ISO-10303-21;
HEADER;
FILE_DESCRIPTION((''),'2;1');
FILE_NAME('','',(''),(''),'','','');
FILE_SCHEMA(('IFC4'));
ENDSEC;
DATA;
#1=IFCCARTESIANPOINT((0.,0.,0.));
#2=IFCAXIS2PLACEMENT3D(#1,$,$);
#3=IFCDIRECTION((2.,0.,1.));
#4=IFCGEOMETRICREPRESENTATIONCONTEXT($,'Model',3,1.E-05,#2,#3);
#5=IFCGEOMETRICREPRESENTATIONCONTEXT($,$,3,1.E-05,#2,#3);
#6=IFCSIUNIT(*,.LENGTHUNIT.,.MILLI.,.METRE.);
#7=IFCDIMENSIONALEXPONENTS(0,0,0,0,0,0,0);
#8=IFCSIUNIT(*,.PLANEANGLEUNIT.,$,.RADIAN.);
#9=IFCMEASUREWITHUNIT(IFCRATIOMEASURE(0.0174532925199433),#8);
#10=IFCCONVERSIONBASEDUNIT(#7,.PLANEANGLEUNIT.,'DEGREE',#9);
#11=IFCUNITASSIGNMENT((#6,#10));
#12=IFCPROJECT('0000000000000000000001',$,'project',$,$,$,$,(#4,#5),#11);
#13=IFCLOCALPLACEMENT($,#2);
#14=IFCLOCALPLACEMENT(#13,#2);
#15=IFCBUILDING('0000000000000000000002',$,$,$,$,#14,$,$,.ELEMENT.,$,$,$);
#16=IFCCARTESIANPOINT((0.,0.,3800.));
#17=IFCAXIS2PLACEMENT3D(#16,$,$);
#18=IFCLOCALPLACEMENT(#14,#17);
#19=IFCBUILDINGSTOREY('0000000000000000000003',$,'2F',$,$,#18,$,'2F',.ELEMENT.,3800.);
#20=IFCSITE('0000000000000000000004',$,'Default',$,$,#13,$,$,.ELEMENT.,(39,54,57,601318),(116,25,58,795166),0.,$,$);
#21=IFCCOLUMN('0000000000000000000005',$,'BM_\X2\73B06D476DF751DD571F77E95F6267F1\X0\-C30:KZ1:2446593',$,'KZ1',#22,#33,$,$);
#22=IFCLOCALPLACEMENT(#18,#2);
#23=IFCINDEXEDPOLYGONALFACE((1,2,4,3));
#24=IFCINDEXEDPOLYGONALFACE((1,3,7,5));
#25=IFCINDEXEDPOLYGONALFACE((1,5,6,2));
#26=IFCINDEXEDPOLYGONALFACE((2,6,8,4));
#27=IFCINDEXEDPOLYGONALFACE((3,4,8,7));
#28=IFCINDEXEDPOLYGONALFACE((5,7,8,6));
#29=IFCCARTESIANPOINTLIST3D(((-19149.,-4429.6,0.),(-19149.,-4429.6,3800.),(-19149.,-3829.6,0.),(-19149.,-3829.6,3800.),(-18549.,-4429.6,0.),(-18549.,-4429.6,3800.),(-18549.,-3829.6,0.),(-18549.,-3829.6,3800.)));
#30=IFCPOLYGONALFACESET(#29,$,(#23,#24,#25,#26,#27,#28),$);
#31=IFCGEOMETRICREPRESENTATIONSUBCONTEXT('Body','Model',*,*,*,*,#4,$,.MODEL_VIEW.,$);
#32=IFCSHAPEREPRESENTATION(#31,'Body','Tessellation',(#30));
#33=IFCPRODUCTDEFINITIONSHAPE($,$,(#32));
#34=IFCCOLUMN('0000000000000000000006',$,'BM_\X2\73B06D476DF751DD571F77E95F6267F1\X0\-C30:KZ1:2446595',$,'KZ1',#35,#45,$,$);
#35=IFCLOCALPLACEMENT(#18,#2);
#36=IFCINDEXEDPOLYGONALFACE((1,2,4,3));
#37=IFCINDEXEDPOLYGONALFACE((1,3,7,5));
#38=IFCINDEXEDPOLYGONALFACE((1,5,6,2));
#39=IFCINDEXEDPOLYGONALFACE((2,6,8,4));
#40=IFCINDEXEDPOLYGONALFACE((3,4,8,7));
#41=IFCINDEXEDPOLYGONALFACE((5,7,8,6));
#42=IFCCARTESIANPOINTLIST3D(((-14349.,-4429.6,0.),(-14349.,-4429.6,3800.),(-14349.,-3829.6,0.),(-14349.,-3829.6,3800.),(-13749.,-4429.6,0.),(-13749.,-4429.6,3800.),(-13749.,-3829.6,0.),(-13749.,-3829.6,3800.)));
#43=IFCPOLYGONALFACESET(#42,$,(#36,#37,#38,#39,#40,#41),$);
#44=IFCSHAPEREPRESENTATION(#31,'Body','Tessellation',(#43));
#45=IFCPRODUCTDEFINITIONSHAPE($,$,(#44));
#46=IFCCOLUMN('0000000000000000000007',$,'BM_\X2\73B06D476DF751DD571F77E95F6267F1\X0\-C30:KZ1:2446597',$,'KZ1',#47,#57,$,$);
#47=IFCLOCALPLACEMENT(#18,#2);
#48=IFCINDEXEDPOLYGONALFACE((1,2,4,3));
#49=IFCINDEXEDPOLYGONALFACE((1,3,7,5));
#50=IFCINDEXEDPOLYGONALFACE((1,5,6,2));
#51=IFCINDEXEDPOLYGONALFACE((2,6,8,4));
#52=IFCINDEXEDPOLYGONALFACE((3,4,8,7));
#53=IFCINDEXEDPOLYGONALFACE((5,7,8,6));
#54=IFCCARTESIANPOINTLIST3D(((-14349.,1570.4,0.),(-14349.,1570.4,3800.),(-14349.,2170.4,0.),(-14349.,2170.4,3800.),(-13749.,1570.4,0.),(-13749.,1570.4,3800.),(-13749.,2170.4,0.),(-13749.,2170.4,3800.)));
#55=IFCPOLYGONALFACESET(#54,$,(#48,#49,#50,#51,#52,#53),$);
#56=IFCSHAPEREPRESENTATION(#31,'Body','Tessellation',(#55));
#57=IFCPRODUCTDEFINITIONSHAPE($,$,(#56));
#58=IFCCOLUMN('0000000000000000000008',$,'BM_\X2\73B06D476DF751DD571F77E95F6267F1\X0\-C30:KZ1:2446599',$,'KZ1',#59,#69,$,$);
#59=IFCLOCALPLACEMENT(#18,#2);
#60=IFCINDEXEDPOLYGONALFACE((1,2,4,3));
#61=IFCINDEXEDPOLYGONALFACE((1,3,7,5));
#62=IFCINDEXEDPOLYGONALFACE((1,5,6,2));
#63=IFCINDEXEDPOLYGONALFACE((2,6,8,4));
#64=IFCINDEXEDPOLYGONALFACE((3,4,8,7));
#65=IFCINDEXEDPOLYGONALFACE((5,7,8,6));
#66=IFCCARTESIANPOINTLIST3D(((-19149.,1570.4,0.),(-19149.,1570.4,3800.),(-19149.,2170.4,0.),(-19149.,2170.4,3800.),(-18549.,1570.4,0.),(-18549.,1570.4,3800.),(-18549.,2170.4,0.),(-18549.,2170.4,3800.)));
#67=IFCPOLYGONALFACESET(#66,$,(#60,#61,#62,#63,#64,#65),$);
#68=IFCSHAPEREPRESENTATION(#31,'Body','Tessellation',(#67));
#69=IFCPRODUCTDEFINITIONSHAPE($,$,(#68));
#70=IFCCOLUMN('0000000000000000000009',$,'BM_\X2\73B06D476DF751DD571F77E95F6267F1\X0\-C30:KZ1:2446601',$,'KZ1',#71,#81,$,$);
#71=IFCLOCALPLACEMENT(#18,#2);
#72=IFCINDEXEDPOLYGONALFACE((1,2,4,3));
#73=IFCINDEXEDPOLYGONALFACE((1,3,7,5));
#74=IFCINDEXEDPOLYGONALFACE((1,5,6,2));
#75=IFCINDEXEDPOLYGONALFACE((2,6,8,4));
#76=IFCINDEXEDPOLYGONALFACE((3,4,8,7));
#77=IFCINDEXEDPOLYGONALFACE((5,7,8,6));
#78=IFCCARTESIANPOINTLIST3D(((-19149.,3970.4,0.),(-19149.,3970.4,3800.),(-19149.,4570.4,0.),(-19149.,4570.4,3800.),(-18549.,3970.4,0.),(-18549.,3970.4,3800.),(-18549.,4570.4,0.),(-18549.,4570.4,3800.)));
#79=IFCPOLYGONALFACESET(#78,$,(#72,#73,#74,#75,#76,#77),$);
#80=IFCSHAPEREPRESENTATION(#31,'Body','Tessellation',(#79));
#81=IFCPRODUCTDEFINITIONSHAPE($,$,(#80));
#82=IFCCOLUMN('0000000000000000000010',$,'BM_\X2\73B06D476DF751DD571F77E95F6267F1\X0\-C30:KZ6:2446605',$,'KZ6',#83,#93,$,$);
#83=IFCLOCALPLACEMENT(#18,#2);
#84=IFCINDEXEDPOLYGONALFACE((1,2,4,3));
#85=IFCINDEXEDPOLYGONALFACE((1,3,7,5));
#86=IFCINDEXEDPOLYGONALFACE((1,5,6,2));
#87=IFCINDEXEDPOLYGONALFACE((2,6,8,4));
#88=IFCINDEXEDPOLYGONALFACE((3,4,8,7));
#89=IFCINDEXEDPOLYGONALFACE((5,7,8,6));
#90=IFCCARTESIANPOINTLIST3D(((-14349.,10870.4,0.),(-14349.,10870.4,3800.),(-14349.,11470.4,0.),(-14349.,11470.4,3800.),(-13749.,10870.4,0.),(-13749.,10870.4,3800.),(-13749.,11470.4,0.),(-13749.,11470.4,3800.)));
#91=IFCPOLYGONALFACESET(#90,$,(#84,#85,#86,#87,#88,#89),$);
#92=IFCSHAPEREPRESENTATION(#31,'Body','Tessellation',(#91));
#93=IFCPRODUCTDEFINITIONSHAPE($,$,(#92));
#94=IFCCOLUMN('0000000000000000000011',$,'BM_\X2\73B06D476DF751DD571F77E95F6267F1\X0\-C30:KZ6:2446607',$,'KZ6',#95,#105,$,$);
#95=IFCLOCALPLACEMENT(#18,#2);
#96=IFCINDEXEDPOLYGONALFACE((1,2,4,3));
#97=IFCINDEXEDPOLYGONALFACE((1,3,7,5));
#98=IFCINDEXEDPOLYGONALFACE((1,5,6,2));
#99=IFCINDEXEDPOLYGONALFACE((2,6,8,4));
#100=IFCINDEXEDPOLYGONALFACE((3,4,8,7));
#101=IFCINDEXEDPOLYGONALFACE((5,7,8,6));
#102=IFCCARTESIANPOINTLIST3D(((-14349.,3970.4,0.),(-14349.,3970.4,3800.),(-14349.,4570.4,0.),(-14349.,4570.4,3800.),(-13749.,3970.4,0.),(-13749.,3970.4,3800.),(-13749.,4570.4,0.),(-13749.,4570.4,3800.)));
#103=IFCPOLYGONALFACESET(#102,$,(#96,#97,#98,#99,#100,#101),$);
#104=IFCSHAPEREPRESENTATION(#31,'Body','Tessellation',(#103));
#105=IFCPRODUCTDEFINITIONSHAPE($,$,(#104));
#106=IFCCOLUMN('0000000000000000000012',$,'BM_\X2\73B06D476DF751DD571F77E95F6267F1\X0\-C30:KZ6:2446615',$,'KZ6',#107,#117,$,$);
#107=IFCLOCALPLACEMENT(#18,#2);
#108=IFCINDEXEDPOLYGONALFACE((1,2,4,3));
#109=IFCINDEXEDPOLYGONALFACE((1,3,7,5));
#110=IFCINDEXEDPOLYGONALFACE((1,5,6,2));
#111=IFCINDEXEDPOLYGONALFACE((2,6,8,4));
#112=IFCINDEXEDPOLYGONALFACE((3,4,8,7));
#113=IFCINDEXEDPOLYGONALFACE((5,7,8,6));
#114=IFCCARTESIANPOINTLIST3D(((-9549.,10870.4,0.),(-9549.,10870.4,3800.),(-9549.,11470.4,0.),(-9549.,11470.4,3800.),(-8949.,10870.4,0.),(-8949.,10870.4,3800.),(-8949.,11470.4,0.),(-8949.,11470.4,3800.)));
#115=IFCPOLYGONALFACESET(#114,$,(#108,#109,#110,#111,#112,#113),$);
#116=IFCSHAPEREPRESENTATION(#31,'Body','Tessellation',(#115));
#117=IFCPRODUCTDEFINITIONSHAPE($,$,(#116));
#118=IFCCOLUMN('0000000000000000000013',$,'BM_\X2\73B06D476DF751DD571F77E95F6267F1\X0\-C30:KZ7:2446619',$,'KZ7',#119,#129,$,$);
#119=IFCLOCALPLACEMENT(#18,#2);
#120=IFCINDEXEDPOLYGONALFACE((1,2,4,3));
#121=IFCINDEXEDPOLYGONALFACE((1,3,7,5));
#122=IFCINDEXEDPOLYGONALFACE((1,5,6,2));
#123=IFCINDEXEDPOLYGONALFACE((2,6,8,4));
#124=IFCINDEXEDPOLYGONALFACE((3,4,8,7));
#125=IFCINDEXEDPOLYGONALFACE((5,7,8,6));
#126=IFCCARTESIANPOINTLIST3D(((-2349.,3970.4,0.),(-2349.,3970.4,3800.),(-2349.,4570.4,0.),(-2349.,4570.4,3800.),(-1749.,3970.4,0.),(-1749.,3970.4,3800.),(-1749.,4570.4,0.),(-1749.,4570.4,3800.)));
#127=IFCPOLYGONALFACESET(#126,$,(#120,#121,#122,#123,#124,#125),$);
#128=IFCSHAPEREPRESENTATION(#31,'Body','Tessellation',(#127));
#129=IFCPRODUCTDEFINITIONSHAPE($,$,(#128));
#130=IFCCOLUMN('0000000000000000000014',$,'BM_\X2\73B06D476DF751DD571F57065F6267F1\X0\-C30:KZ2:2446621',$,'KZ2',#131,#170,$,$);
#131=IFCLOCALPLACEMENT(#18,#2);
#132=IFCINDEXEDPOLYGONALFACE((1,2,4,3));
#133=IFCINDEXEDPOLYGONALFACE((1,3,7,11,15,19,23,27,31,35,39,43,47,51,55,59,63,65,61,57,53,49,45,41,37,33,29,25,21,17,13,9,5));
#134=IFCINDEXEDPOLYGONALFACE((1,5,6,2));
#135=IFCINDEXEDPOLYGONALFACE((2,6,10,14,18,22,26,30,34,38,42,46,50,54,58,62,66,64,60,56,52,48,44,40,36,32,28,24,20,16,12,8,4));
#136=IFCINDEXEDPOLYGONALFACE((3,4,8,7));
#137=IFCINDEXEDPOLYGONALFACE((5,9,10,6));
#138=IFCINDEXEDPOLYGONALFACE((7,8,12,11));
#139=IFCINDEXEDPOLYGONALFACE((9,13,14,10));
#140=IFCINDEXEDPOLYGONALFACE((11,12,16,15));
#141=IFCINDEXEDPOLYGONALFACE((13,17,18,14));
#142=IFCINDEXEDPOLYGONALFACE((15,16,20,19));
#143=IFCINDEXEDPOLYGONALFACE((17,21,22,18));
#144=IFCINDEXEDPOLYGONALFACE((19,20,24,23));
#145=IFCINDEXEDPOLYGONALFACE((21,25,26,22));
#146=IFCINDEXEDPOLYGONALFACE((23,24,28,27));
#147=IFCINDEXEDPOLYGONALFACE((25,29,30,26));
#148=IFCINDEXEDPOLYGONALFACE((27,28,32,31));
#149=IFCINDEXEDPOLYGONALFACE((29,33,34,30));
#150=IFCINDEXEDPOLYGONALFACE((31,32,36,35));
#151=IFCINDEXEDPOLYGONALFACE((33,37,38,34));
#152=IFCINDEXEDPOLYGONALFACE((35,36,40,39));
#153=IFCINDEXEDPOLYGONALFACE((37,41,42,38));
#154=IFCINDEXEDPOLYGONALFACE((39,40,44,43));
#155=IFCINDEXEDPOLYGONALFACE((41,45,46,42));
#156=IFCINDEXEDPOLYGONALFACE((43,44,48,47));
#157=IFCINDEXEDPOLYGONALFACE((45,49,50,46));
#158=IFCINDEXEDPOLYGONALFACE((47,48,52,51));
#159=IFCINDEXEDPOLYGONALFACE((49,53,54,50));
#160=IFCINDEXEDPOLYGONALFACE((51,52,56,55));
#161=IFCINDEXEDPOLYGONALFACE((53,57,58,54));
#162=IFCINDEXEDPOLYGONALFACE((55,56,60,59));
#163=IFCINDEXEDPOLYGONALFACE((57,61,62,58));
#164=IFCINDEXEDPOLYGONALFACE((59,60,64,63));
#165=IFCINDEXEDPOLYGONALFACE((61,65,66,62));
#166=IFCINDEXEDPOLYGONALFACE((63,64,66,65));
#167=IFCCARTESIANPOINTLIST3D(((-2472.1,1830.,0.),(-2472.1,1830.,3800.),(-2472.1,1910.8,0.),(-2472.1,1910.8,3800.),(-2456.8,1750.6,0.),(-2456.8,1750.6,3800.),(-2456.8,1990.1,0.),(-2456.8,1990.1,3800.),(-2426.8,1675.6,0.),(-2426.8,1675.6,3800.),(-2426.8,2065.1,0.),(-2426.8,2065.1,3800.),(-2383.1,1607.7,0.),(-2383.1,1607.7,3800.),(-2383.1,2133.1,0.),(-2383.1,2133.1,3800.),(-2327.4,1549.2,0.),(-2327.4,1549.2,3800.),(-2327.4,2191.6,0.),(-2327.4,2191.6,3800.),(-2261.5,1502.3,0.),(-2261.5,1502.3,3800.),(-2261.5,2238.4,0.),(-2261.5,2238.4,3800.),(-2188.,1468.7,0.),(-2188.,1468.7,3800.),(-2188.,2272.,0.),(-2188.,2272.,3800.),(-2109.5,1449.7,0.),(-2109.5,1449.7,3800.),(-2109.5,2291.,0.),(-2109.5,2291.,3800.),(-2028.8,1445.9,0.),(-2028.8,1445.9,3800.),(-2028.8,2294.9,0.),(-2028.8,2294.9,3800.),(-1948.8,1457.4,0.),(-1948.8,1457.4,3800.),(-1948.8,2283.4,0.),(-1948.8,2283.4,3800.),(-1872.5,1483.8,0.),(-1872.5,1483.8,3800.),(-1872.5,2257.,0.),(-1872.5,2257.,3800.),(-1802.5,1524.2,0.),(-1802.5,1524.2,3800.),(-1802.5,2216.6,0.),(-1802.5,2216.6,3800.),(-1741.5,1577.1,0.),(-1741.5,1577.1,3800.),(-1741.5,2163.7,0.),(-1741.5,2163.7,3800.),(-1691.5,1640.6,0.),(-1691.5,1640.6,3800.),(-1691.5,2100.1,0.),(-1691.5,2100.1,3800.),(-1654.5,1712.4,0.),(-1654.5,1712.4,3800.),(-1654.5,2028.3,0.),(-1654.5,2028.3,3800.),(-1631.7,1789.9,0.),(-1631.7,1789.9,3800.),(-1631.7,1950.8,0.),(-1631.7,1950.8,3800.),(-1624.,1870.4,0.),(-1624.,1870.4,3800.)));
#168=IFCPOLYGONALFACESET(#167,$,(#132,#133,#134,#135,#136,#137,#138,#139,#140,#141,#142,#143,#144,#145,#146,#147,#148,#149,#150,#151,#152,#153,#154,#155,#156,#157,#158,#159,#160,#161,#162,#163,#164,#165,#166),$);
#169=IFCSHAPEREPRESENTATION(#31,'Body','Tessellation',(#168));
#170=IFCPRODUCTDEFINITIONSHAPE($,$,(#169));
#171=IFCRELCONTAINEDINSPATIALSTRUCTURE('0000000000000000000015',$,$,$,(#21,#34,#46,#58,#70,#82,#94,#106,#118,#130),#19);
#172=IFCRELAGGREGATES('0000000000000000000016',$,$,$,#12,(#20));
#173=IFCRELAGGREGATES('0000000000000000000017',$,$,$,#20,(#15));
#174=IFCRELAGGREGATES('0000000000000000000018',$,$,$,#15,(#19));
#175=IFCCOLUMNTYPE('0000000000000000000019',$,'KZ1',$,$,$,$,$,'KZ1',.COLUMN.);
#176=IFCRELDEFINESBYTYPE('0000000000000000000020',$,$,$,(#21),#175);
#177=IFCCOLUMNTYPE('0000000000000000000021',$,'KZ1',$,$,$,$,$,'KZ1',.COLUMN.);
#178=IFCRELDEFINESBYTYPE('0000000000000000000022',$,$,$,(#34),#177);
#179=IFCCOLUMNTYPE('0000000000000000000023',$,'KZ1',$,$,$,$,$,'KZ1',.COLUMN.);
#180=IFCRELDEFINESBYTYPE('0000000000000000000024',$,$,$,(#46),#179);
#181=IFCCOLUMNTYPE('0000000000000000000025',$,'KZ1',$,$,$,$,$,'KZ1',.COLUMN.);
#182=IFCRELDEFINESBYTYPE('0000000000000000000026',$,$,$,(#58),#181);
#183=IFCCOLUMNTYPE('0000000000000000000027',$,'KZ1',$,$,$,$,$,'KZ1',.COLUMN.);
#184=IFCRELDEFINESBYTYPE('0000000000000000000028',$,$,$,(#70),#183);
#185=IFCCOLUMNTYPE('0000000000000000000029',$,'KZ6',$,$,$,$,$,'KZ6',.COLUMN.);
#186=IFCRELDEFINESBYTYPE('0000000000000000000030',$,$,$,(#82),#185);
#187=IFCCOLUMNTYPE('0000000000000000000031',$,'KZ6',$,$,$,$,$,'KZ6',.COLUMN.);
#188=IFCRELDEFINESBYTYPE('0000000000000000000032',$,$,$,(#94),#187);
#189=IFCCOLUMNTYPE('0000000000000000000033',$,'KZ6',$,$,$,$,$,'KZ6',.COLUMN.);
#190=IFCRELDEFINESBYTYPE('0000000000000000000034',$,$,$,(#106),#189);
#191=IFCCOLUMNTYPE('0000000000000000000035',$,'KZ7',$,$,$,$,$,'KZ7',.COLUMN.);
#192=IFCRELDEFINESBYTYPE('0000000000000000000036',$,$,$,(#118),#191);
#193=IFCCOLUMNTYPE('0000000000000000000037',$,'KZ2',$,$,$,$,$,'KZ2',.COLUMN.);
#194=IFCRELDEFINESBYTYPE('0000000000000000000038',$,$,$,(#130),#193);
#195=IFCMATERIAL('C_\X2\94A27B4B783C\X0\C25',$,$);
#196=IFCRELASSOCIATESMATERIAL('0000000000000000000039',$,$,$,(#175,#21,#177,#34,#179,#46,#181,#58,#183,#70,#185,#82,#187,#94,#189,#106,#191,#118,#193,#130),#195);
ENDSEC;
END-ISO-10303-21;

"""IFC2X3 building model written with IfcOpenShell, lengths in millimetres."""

from ifc_helpers import new_model, entity, si_unit, converted_unit, direction, frame, frame_2d, origin, origin_2d_with_axis, place, context, subcontext, project, spatial, rectangle, circle, extrude, source, transform, mapped, material, type_object, type_shapes, element, save


model = new_model("IFC2X3")

# Units and contexts
model_context = context("Model", 3, precision=1e-05, world=origin(), true_north=direction((2.0, 0.0, 1.0)))
context_of_model = context(None, 3, precision=1e-05, world=origin(), true_north=direction((2.0, 0.0, 1.0)))
body_context = subcontext(model_context, "Body", "Model", "MODEL_VIEW")
ifc_project = project(units=[si_unit("LENGTHUNIT", "METRE", prefix="MILLI"), converted_unit("PLANEANGLEUNIT", "DEGREE", entity("IfcRatioMeasure", 0.0174532925199433), si_unit("PLANEANGLEUNIT", "RADIAN"), dimensions=[0, 0, 0, 0, 0, 0, 0])], contexts=[model_context, context_of_model])

# Site, building, storey
site_placement = place(None, origin())
site = spatial("IfcSite", under=ifc_project, at=site_placement, Name="Default", CompositionType="ELEMENT", RefLatitude=(39, 54, 57, 601318), RefLongitude=(116, 25, 58, 795166), RefElevation=0.0)
building_placement = place(site_placement, origin())
building = spatial("IfcBuilding", under=site, at=building_placement, CompositionType="ELEMENT")
storey_placement = place(building_placement, frame((0.0, 0.0, 3800.0)))
storey = spatial("IfcBuildingStorey", under=building, at=storey_placement, Name="2F", LongName="2F", CompositionType="ELEMENT", Elevation=3800.0)

# Columns
ifc_material_1 = material(Name="C_钢筋砼C25")
column_type_1 = type_object("IfcColumnType", Name="KZ1", ElementType="KZ1", PredefinedType="COLUMN", material=ifc_material_1)
shared_shape_1 = source(origin(), body_context, "Body", "SweptSolid", [
    extrude(rectangle(XDim=600.0, YDim=600.0, at=frame_2d((0.0, 0.0), x_axis=(1.0, 0.0))), frame((-18849.0, -4129.6, 3800.0), z_axis=(0.0, 0.0, 1.0), x_axis=(-1.0, 0.0, 0.0)), (0.0, 0.0, 1.0), 3800.0),
])
type_shapes(column_type_1, [shared_shape_1])
column_1_placement = place(storey_placement, frame((0.0, 0.0, -3800.0)))
element("IfcColumn", 1, at=column_1_placement, inside=storey, type_object=column_type_1, material=ifc_material_1, Name="BM_现浇混凝土矩形柱-C30:KZ1:2446593", ObjectType="KZ1", context=body_context, shape_type="MappedRepresentation", body=[
    mapped(shared_shape_1, transform((0.0, 0.0, 0.0), scale=1.0)),
])
column_type_2 = type_object("IfcColumnType", Name="KZ1", ElementType="KZ1", PredefinedType="COLUMN", material=ifc_material_1)
shared_shape_2 = source(origin(), body_context, "Body", "SweptSolid", [
    extrude(rectangle(XDim=600.0, YDim=600.0, at=frame_2d((0.0, 0.0), x_axis=(1.0, 0.0))), frame((-14049.0, -4129.6, 3800.0), z_axis=(0.0, 0.0, 1.0), x_axis=(-1.0, 0.0, 0.0)), (0.0, 0.0, 1.0), 3800.0),
])
type_shapes(column_type_2, [shared_shape_2])
column_2_placement = place(storey_placement, frame((0.0, 0.0, -3800.0)))
element("IfcColumn", 2, at=column_2_placement, inside=storey, type_object=column_type_2, material=ifc_material_1, Name="BM_现浇混凝土矩形柱-C30:KZ1:2446595", ObjectType="KZ1", context=body_context, shape_type="MappedRepresentation", body=[
    mapped(shared_shape_2, transform((0.0, 0.0, 0.0), scale=1.0)),
])
column_type_3 = type_object("IfcColumnType", Name="KZ1", ElementType="KZ1", PredefinedType="COLUMN", material=ifc_material_1)
shared_shape_3 = source(origin(), body_context, "Body", "SweptSolid", [
    extrude(rectangle(XDim=600.0, YDim=600.0, at=frame_2d((0.0, 0.0), x_axis=(1.0, 0.0))), frame((-14049.0, 1870.4, 3800.0), z_axis=(0.0, 0.0, 1.0), x_axis=(-1.0, 0.0, 0.0)), (0.0, 0.0, 1.0), 3800.0),
])
type_shapes(column_type_3, [shared_shape_3])
column_3_placement = place(storey_placement, frame((0.0, 0.0, -3800.0)))
element("IfcColumn", 3, at=column_3_placement, inside=storey, type_object=column_type_3, material=ifc_material_1, Name="BM_现浇混凝土矩形柱-C30:KZ1:2446597", ObjectType="KZ1", context=body_context, shape_type="MappedRepresentation", body=[
    mapped(shared_shape_3, transform((0.0, 0.0, 0.0), scale=1.0)),
])
column_type_4 = type_object("IfcColumnType", Name="KZ1", ElementType="KZ1", PredefinedType="COLUMN", material=ifc_material_1)
shared_shape_4 = source(origin(), body_context, "Body", "SweptSolid", [
    extrude(rectangle(XDim=600.0, YDim=600.0, at=frame_2d((0.0, 0.0), x_axis=(1.0, 0.0))), frame((-18849.0, 1870.4, 3800.0), z_axis=(0.0, 0.0, 1.0), x_axis=(-1.0, 0.0, 0.0)), (0.0, 0.0, 1.0), 3800.0),
])
type_shapes(column_type_4, [shared_shape_4])
column_4_placement = place(storey_placement, frame((0.0, 0.0, -3800.0)))
element("IfcColumn", 4, at=column_4_placement, inside=storey, type_object=column_type_4, material=ifc_material_1, Name="BM_现浇混凝土矩形柱-C30:KZ1:2446599", ObjectType="KZ1", context=body_context, shape_type="MappedRepresentation", body=[
    mapped(shared_shape_4, transform((0.0, 0.0, 0.0), scale=1.0)),
])
column_type_5 = type_object("IfcColumnType", Name="KZ1", ElementType="KZ1", PredefinedType="COLUMN", material=ifc_material_1)
shared_shape_5 = source(origin(), body_context, "Body", "SweptSolid", [
    extrude(rectangle(XDim=600.0, YDim=600.0, at=frame_2d((0.0, 0.0), x_axis=(1.0, 0.0))), frame((-18849.0, 4270.4, 3800.0), z_axis=(0.0, 0.0, 1.0), x_axis=(-1.0, 0.0, 0.0)), (0.0, 0.0, 1.0), 3800.0),
])
type_shapes(column_type_5, [shared_shape_5])
column_5_placement = place(storey_placement, frame((0.0, 0.0, -3800.0)))
element("IfcColumn", 5, at=column_5_placement, inside=storey, type_object=column_type_5, material=ifc_material_1, Name="BM_现浇混凝土矩形柱-C30:KZ1:2446601", ObjectType="KZ1", context=body_context, shape_type="MappedRepresentation", body=[
    mapped(shared_shape_5, transform((0.0, 0.0, 0.0), scale=1.0)),
])
column_type_6 = type_object("IfcColumnType", Name="KZ6", ElementType="KZ6", PredefinedType="COLUMN", material=ifc_material_1)
shared_shape_6 = source(origin(), body_context, "Body", "SweptSolid", [
    extrude(rectangle(XDim=600.0, YDim=600.0, at=frame_2d((0.0, 0.0), x_axis=(1.0, 0.0))), frame((-14049.0, 11170.4, 3800.0), z_axis=(0.0, 0.0, 1.0), x_axis=(-1.0, 0.0, 0.0)), (0.0, 0.0, 1.0), 3800.0),
])
type_shapes(column_type_6, [shared_shape_6])
column_6_placement = place(storey_placement, frame((0.0, 0.0, -3800.0)))
element("IfcColumn", 6, at=column_6_placement, inside=storey, type_object=column_type_6, material=ifc_material_1, Name="BM_现浇混凝土矩形柱-C30:KZ6:2446605", ObjectType="KZ6", context=body_context, shape_type="MappedRepresentation", body=[
    mapped(shared_shape_6, transform((0.0, 0.0, 0.0), scale=1.0)),
])
column_type_7 = type_object("IfcColumnType", Name="KZ6", ElementType="KZ6", PredefinedType="COLUMN", material=ifc_material_1)
shared_shape_7 = source(origin(), body_context, "Body", "SweptSolid", [
    extrude(rectangle(XDim=600.0, YDim=600.0, at=frame_2d((0.0, 0.0), x_axis=(1.0, 0.0))), frame((-14049.0, 4270.4, 3800.0), z_axis=(0.0, 0.0, 1.0), x_axis=(-1.0, 0.0, 0.0)), (0.0, 0.0, 1.0), 3800.0),
])
type_shapes(column_type_7, [shared_shape_7])
column_7_placement = place(storey_placement, frame((0.0, 0.0, -3800.0)))
element("IfcColumn", 7, at=column_7_placement, inside=storey, type_object=column_type_7, material=ifc_material_1, Name="BM_现浇混凝土矩形柱-C30:KZ6:2446607", ObjectType="KZ6", context=body_context, shape_type="MappedRepresentation", body=[
    mapped(shared_shape_7, transform((0.0, 0.0, 0.0), scale=1.0)),
])
column_type_8 = type_object("IfcColumnType", Name="KZ6", ElementType="KZ6", PredefinedType="COLUMN", material=ifc_material_1)
shared_shape_8 = source(origin(), body_context, "Body", "SweptSolid", [
    extrude(rectangle(XDim=600.0, YDim=600.0, at=frame_2d((0.0, 0.0), x_axis=(1.0, 0.0))), frame((-9249.0, 11170.4, 3800.0), z_axis=(0.0, 0.0, 1.0), x_axis=(-1.0, 0.0, 0.0)), (0.0, 0.0, 1.0), 3800.0),
])
type_shapes(column_type_8, [shared_shape_8])
column_8_placement = place(storey_placement, frame((0.0, 0.0, -3800.0)))
element("IfcColumn", 8, at=column_8_placement, inside=storey, type_object=column_type_8, material=ifc_material_1, Name="BM_现浇混凝土矩形柱-C30:KZ6:2446615", ObjectType="KZ6", context=body_context, shape_type="MappedRepresentation", body=[
    mapped(shared_shape_8, transform((0.0, 0.0, 0.0), scale=1.0)),
])
column_type_9 = type_object("IfcColumnType", Name="KZ7", ElementType="KZ7", PredefinedType="COLUMN", material=ifc_material_1)
shared_shape_9 = source(origin(), body_context, "Body", "SweptSolid", [
    extrude(rectangle(XDim=600.0, YDim=600.0, at=origin_2d_with_axis()), frame((-2049.0, 4270.4, 3800.0), z_axis=(0.0, 0.0, 1.0), x_axis=(-1.0, 0.0, 0.0)), (0.0, 0.0, 1.0), 3800.0),
])
type_shapes(column_type_9, [shared_shape_9])
column_9_placement = place(storey_placement, frame((0.0, 0.0, -3800.0)))
element("IfcColumn", 9, at=column_9_placement, inside=storey, type_object=column_type_9, material=ifc_material_1, Name="BM_现浇混凝土矩形柱-C30:KZ7:2446619", ObjectType="KZ7", context=body_context, shape_type="MappedRepresentation", body=[
    mapped(shared_shape_9, transform((0.0, 0.0, 0.0), scale=1.0)),
])
column_type_10 = type_object("IfcColumnType", Name="KZ2", ElementType="KZ2", PredefinedType="COLUMN", material=ifc_material_1)
shared_shape_10 = source(origin(), body_context, "Body", "SweptSolid", [
    extrude(circle(Radius=425.0, at=frame_2d((0.0, 0.0), x_axis=(1.0, 0.0))), frame((-2049.0, 1870.4, 3800.0)), (0.0, 0.0, 1.0), 3800.0),
])
type_shapes(column_type_10, [shared_shape_10])
column_10_placement = place(storey_placement, frame((0.0, 0.0, -3800.0)))
element("IfcColumn", 10, at=column_10_placement, inside=storey, type_object=column_type_10, material=ifc_material_1, Name="BM_现浇混凝土圆形柱-C30:KZ2:2446621", ObjectType="KZ2", context=body_context, shape_type="MappedRepresentation", body=[
    mapped(shared_shape_10, transform((0.0, 0.0, 0.0), scale=1.0)),
])

save(model, "model.ifc")
